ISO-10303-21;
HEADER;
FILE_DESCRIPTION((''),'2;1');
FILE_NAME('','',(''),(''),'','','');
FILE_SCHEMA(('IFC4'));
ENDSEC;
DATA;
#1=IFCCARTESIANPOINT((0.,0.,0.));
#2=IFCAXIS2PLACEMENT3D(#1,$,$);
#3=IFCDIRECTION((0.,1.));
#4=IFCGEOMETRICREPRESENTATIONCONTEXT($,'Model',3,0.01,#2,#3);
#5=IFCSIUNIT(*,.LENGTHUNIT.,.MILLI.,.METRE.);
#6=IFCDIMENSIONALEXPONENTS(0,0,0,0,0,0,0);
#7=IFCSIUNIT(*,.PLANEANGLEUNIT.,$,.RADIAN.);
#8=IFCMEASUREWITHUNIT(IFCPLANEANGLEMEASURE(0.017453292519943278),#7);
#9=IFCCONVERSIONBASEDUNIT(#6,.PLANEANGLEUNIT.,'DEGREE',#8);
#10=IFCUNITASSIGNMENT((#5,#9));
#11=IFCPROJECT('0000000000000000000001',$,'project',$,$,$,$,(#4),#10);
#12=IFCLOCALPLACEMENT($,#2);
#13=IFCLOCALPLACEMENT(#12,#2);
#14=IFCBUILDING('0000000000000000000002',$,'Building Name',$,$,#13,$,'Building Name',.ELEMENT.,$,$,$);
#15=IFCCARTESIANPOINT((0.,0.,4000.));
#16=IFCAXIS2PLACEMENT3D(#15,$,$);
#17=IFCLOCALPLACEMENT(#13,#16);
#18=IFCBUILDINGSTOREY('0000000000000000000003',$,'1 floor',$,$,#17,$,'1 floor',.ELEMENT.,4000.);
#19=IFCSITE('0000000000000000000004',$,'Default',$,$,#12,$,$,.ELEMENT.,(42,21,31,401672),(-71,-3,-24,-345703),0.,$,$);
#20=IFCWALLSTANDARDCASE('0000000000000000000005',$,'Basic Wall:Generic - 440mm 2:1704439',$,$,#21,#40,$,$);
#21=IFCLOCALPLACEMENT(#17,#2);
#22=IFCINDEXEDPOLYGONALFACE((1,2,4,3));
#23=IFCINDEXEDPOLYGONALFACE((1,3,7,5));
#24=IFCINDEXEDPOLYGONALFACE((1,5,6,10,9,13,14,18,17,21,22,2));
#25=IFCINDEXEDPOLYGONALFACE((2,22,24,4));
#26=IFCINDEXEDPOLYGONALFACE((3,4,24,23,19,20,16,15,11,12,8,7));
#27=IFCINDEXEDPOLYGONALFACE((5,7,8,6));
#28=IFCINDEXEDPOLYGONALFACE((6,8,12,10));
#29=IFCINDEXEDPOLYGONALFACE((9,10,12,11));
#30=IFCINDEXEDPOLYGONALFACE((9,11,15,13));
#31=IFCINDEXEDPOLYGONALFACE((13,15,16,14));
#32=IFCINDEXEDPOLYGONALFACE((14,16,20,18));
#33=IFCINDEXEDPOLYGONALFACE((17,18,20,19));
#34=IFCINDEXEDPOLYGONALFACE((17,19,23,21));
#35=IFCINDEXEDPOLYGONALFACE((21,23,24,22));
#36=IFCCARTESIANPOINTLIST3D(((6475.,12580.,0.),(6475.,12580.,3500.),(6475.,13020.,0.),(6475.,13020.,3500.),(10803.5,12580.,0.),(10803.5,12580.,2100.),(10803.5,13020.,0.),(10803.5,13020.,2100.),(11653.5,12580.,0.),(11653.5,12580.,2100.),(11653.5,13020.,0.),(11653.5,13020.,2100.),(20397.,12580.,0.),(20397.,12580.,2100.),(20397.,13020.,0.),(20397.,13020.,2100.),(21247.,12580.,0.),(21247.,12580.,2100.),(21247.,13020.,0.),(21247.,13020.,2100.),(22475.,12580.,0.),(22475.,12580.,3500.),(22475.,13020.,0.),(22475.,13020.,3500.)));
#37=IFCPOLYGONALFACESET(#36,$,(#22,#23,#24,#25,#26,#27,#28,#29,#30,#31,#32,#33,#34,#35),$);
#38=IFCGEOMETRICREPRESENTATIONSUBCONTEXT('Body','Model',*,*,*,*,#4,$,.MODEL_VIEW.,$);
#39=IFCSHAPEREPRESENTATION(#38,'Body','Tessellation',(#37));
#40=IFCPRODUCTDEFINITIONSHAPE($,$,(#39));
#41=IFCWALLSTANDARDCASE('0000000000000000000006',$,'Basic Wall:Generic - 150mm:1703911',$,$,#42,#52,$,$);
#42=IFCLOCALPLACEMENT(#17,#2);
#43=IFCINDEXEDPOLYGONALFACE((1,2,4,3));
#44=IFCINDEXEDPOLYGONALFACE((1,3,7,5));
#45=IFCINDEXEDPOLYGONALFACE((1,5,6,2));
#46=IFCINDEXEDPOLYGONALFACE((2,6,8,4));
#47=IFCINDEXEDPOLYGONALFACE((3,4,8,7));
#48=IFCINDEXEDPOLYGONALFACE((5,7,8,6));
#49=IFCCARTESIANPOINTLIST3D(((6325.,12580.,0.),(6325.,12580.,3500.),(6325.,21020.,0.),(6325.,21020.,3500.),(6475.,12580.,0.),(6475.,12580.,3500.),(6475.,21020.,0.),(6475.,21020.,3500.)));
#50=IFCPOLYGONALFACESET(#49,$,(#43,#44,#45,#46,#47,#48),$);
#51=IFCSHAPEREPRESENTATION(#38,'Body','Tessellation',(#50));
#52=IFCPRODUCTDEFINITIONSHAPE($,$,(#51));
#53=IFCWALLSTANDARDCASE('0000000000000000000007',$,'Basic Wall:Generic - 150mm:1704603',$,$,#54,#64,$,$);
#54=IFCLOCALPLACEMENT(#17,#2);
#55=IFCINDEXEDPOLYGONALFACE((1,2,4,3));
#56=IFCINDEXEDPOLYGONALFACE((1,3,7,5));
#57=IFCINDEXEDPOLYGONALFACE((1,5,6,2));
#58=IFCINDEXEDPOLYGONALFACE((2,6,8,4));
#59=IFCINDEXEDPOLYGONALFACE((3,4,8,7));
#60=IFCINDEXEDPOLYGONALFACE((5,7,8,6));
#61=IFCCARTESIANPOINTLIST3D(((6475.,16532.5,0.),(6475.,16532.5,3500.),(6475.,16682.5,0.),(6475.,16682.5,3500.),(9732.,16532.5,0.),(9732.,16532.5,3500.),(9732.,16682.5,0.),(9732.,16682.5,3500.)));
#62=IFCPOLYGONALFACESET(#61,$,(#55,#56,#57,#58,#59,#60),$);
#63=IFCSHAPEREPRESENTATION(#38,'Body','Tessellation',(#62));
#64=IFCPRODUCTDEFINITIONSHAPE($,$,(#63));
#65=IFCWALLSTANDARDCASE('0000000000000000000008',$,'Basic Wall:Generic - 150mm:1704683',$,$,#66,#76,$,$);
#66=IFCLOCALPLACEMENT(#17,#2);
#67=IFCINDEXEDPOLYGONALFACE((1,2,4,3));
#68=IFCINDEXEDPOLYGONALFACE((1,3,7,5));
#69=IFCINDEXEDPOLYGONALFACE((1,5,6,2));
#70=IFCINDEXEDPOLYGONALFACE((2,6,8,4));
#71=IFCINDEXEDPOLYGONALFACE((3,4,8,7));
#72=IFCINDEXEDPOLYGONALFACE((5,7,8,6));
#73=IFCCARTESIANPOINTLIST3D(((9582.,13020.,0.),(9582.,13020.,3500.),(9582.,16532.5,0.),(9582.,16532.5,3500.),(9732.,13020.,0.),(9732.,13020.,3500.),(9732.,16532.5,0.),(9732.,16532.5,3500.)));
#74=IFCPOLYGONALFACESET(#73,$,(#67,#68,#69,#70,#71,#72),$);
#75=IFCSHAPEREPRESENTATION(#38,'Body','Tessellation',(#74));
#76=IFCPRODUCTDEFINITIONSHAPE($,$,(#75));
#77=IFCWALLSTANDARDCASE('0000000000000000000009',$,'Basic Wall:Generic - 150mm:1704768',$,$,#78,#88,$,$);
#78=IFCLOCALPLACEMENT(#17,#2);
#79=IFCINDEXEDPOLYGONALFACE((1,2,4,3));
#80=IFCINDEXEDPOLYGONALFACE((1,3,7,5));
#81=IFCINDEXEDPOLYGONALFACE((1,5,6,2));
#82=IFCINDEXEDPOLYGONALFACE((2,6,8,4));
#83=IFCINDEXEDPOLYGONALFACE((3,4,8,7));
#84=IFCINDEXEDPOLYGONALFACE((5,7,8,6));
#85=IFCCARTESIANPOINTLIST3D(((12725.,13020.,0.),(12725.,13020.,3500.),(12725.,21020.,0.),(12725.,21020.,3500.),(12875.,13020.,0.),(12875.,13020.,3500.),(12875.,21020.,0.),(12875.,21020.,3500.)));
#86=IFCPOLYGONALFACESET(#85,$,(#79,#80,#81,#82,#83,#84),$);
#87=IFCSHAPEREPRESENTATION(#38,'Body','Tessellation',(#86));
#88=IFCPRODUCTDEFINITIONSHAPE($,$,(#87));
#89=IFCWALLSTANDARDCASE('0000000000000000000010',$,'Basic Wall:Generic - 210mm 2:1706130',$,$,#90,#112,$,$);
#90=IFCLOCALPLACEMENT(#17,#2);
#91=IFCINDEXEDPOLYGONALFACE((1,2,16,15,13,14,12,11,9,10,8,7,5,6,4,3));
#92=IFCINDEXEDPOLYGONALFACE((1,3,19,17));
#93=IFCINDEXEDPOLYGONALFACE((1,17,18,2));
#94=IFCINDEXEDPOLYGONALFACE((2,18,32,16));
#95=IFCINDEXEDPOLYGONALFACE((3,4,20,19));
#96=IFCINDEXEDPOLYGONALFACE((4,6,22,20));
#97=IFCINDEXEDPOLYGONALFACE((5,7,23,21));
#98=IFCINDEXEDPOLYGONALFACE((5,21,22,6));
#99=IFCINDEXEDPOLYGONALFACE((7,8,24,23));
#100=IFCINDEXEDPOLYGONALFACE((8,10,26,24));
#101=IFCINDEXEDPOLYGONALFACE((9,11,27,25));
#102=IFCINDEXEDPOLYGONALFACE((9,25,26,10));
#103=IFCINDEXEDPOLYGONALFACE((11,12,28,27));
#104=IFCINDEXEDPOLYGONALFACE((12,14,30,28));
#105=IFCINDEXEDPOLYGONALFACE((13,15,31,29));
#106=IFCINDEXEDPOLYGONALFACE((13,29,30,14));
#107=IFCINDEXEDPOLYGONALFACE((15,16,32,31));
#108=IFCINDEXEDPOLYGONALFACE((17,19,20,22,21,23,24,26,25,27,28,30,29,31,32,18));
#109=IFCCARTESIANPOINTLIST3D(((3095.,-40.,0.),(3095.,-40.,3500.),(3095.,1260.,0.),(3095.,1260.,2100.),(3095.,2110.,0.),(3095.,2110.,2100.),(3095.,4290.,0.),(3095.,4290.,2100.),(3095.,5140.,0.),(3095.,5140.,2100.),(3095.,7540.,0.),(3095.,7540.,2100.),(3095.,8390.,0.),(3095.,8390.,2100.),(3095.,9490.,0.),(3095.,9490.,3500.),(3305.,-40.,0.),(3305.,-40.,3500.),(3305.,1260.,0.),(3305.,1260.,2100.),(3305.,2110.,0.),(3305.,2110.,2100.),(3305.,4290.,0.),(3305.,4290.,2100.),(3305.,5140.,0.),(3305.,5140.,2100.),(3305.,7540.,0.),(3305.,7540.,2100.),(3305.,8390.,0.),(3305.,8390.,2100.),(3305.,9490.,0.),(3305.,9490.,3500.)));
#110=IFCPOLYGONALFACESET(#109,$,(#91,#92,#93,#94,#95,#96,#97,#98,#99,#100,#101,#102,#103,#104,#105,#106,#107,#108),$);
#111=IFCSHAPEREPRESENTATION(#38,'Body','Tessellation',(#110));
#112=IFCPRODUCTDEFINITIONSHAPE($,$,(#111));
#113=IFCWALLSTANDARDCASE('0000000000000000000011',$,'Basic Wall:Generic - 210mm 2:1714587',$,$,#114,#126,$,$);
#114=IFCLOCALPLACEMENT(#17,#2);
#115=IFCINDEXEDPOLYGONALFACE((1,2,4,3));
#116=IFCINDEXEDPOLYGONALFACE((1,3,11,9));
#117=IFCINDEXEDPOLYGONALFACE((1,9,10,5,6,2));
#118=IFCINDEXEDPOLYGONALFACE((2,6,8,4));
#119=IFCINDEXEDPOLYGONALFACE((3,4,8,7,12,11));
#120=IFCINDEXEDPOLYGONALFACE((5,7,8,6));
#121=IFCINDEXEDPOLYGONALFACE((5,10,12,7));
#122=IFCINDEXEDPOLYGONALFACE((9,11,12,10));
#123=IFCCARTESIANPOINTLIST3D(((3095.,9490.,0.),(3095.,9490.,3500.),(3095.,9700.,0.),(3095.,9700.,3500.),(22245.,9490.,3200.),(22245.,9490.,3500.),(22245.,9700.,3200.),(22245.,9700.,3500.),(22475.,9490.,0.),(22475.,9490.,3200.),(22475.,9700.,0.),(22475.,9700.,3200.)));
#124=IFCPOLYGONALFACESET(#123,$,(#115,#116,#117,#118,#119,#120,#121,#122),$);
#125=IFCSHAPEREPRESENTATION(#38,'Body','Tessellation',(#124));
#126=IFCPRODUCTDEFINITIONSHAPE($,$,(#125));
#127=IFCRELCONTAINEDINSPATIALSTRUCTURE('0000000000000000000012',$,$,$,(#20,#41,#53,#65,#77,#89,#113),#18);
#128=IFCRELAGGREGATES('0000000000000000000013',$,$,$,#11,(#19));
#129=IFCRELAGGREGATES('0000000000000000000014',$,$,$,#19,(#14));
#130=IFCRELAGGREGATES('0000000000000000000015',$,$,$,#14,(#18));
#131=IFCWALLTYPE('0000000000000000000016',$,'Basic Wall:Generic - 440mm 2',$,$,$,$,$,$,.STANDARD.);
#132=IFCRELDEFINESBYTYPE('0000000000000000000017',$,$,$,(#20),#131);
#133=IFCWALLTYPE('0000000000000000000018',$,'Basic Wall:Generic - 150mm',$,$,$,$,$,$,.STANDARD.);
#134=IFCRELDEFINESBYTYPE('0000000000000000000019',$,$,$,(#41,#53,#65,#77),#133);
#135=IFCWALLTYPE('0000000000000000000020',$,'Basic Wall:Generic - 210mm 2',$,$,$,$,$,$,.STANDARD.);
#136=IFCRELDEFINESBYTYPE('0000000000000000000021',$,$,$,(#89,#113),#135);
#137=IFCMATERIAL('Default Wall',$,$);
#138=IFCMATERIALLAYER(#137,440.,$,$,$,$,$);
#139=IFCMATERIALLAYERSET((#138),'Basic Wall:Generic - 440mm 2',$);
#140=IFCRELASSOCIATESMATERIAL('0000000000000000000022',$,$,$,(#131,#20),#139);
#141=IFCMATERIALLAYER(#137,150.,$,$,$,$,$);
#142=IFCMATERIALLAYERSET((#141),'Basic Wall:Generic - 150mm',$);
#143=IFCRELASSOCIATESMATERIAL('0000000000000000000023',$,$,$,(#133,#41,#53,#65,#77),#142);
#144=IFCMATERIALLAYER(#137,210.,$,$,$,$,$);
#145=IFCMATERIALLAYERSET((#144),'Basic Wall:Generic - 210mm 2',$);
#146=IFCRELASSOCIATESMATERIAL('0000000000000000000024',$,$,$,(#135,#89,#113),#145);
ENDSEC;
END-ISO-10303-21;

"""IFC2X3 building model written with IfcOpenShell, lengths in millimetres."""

from ifc_helpers import new_model, entity, si_unit, converted_unit, direction, frame, frame_2d, origin, place, context, subcontext, project, spatial, polyline, rectangle, extrude, clip, bounded_halfspace, material, layer, layer_set, layer_usage, type_object, element, save


model = new_model("IFC2X3")

# Units and contexts
model_context = context("Model", 3, precision=0.01, world=origin(), true_north=direction((0.0, 1.0)))
body_context = subcontext(model_context, "Body", "Model", "MODEL_VIEW")
ifc_project = project(units=[si_unit("LENGTHUNIT", "METRE", prefix="MILLI"), converted_unit("PLANEANGLEUNIT", "DEGREE", entity("IfcPlaneAngleMeasure", 0.017453292519943278), si_unit("PLANEANGLEUNIT", "RADIAN"), dimensions=[0, 0, 0, 0, 0, 0, 0])], contexts=[model_context])

# Site, building, storey
site_placement = place(None, origin())
site = spatial("IfcSite", under=ifc_project, at=site_placement, Name="Default", CompositionType="ELEMENT", RefLatitude=(42, 21, 31, 401672), RefLongitude=(-71, -3, -24, -345703), RefElevation=0.0)
building_placement = place(site_placement, origin())
building = spatial("IfcBuilding", under=site, at=building_placement, Name="Building Name", LongName="Building Name", CompositionType="ELEMENT")
storey_placement = place(building_placement, frame((0.0, 0.0, 4000.0)))
storey = spatial("IfcBuildingStorey", under=building, at=storey_placement, Name="1 floor", LongName="1 floor", CompositionType="ELEMENT", Elevation=4000.0)

# Wall, openings
ifc_material_1 = material(Name="Default Wall")
ifc_layer_1 = layer(ifc_material_1, 440.0)
ifc_layer_set_1 = layer_set([ifc_layer_1], Name="Basic Wall:Generic - 440mm 2")
ifc_layer_usage_1 = layer_usage(ifc_layer_set_1, "AXIS2", "NEGATIVE", 220.0)
wall_type_1 = type_object("IfcWallType", Name="Basic Wall:Generic - 440mm 2", PredefinedType="STANDARD", material=ifc_layer_set_1)
wall_1_placement = place(storey_placement, frame((6475.0, 12800.0, 0.0)))
wall_1 = element("IfcWallStandardCase", 1, at=wall_1_placement, inside=storey, type_object=wall_type_1, material=ifc_layer_usage_1, Name="Basic Wall:Generic - 440mm 2:1704439", context=body_context, shape_type="SweptSolid", body=[
    extrude(rectangle(XDim=16000.0, YDim=440.0, at=frame_2d((8000.0, 0.0), x_axis=(-1.0, 0.0))), origin(), (0.0, 0.0, 1.0), 3500.0),
])
opening_1_placement = place(wall_1_placement, frame((4328.5, -220.0, 0.0)))
element("IfcOpeningElement", 2, at=opening_1_placement, cuts=wall_1, ObjectType="Opening", context=body_context, shape_type="SweptSolid", body=[
    extrude(rectangle(XDim=2100.0, YDim=850.0, at=frame_2d((1050.0, 425.0), x_axis=(1.0, 0.0))), frame((0.0, 0.0, 0.0), z_axis=(0.0, 1.0, 0.0), x_axis=(0.0, 0.0, 1.0)), (0.0, 0.0, 1.0), 440.0),
])
opening_2_placement = place(wall_1_placement, frame((13922.0, -220.0, 0.0)))
element("IfcOpeningElement", 3, at=opening_2_placement, cuts=wall_1, ObjectType="Opening", context=body_context, shape_type="SweptSolid", body=[
    extrude(rectangle(XDim=2100.0, YDim=850.0, at=frame_2d((1050.0, 425.0), x_axis=(1.0, 0.0))), frame((0.0, 0.0, 0.0), z_axis=(0.0, 1.0, 0.0), x_axis=(0.0, 0.0, 1.0)), (0.0, 0.0, 1.0), 440.0),
])

# Walls
ifc_layer_2 = layer(ifc_material_1, 150.0)
ifc_layer_set_2 = layer_set([ifc_layer_2], Name="Basic Wall:Generic - 150mm")
ifc_layer_usage_2 = layer_usage(ifc_layer_set_2, "AXIS2", "NEGATIVE", 75.0)
wall_type_2 = type_object("IfcWallType", Name="Basic Wall:Generic - 150mm", PredefinedType="STANDARD", material=ifc_layer_set_2)
wall_2_placement = place(storey_placement, frame((6400.0, 21020.0, 0.0), z_axis=(0.0, 0.0, 1.0), x_axis=(0.0, -1.0, 0.0)))
element("IfcWallStandardCase", 4, at=wall_2_placement, inside=storey, type_object=wall_type_2, material=ifc_layer_usage_2, Name="Basic Wall:Generic - 150mm:1703911", context=body_context, shape_type="SweptSolid", body=[
    extrude(rectangle(XDim=8440.0, YDim=150.0, at=frame_2d((4220.0, 0.0), x_axis=(-1.0, 0.0))), origin(), (0.0, 0.0, 1.0), 3500.0),
])
ifc_layer_usage_3 = layer_usage(ifc_layer_set_2, "AXIS2", "NEGATIVE", 75.0)
wall_3_placement = place(storey_placement, frame((6475.0, 16607.5, 0.0)))
element("IfcWallStandardCase", 5, at=wall_3_placement, inside=storey, type_object=wall_type_2, material=ifc_layer_usage_3, Name="Basic Wall:Generic - 150mm:1704603", context=body_context, shape_type="SweptSolid", body=[
    extrude(rectangle(XDim=3257.0, YDim=150.0, at=frame_2d((1628.5, 0.0), x_axis=(-1.0, 0.0))), origin(), (0.0, 0.0, 1.0), 3500.0),
])
ifc_layer_usage_4 = layer_usage(ifc_layer_set_2, "AXIS2", "NEGATIVE", 75.0)
wall_4_placement = place(storey_placement, frame((9657.0, 16532.5, 0.0), z_axis=(0.0, 0.0, 1.0), x_axis=(0.0, -1.0, 0.0)))
element("IfcWallStandardCase", 6, at=wall_4_placement, inside=storey, type_object=wall_type_2, material=ifc_layer_usage_4, Name="Basic Wall:Generic - 150mm:1704683", context=body_context, shape_type="SweptSolid", body=[
    extrude(rectangle(XDim=3512.5, YDim=150.0, at=frame_2d((1756.2, 0.0), x_axis=(-1.0, 0.0))), origin(), (0.0, 0.0, 1.0), 3500.0),
])
ifc_layer_usage_5 = layer_usage(ifc_layer_set_2, "AXIS2", "NEGATIVE", 75.0)
wall_5_placement = place(storey_placement, frame((12800.0, 21020.0, 0.0), z_axis=(0.0, 0.0, 1.0), x_axis=(0.0, -1.0, 0.0)))
element("IfcWallStandardCase", 7, at=wall_5_placement, inside=storey, type_object=wall_type_2, material=ifc_layer_usage_5, Name="Basic Wall:Generic - 150mm:1704768", context=body_context, shape_type="SweptSolid", body=[
    extrude(rectangle(XDim=8000.0, YDim=150.0, at=frame_2d((4000.0, 0.0), x_axis=(-1.0, 0.0))), origin(), (0.0, 0.0, 1.0), 3500.0),
])

# Wall, openings
ifc_layer_3 = layer(ifc_material_1, 210.0)
ifc_layer_set_3 = layer_set([ifc_layer_3], Name="Basic Wall:Generic - 210mm 2")
ifc_layer_usage_6 = layer_usage(ifc_layer_set_3, "AXIS2", "NEGATIVE", 105.0)
wall_type_3 = type_object("IfcWallType", Name="Basic Wall:Generic - 210mm 2", PredefinedType="STANDARD", material=ifc_layer_set_3)
wall_6_placement = place(storey_placement, frame((3200.0, 9490.0, 0.0), z_axis=(0.0, 0.0, 1.0), x_axis=(0.0, -1.0, 0.0)))
wall_6 = element("IfcWallStandardCase", 8, at=wall_6_placement, inside=storey, type_object=wall_type_3, material=ifc_layer_usage_6, Name="Basic Wall:Generic - 210mm 2:1706130", context=body_context, shape_type="SweptSolid", body=[
    extrude(rectangle(XDim=9530.0, YDim=210.0, at=frame_2d((4765.0, 0.0), x_axis=(1.0, 0.0))), origin(), (0.0, 0.0, 1.0), 3500.0),
])
opening_3_placement = place(wall_6_placement, frame((1950.0, 105.0, 0.0)))
element("IfcOpeningElement", 9, at=opening_3_placement, cuts=wall_6, ObjectType="Opening", context=body_context, shape_type="SweptSolid", body=[
    extrude(rectangle(XDim=2100.0, YDim=850.0, at=frame_2d((1050.0, 425.0), x_axis=(1.0, 0.0))), frame((0.0, 0.0, 0.0), z_axis=(0.0, -1.0, 0.0), x_axis=(0.0, 0.0, 1.0)), (0.0, 0.0, 1.0), 210.0),
])
opening_4_placement = place(wall_6_placement, frame((5200.0, 105.0, 0.0)))
element("IfcOpeningElement", 10, at=opening_4_placement, cuts=wall_6, ObjectType="Opening", context=body_context, shape_type="SweptSolid", body=[
    extrude(rectangle(XDim=2100.0, YDim=850.0, at=frame_2d((1050.0, 425.0), x_axis=(1.0, 0.0))), frame((0.0, 0.0, 0.0), z_axis=(0.0, -1.0, 0.0), x_axis=(0.0, 0.0, 1.0)), (0.0, 0.0, 1.0), 210.0),
])
opening_5_placement = place(wall_6_placement, frame((8230.0, 105.0, 0.0)))
element("IfcOpeningElement", 11, at=opening_5_placement, cuts=wall_6, ObjectType="Opening", context=body_context, shape_type="SweptSolid", body=[
    extrude(rectangle(XDim=2100.0, YDim=850.0, at=frame_2d((1050.0, 425.0), x_axis=(1.0, 0.0))), frame((0.0, 0.0, 0.0), z_axis=(0.0, -1.0, 0.0), x_axis=(0.0, 0.0, 1.0)), (0.0, 0.0, 1.0), 210.0),
])

# Wall
ifc_layer_usage_7 = layer_usage(ifc_layer_set_3, "AXIS2", "NEGATIVE", 105.0)
wall_7_placement = place(storey_placement, frame((3095.0, 9595.0, 0.0)))
element("IfcWallStandardCase", 12, at=wall_7_placement, inside=storey, type_object=wall_type_3, material=ifc_layer_usage_7, Name="Basic Wall:Generic - 210mm 2:1714587", context=body_context, shape_type="Clipping", body=[
    clip(extrude(rectangle(XDim=19380.0, YDim=210.0, at=frame_2d((9690.0, 0.0), x_axis=(-1.0, 0.0))), origin(), (0.0, 0.0, 1.0), 3500.0), bounded_halfspace(frame((19150.0, -105.0, 3200.0), z_axis=(0.0, 0.0, -1.0), x_axis=(0.0, 1.0, 0.0)), True, frame((19150.0, -105.0, 3200.0)), polyline([(0.0, 0.0), (20.0, 0.0), (230.0, 0.0), (230.0, 210.0), (0.0, 210.0), (0.0, 0.0)]))),
])

save(model, "model.ifc")
